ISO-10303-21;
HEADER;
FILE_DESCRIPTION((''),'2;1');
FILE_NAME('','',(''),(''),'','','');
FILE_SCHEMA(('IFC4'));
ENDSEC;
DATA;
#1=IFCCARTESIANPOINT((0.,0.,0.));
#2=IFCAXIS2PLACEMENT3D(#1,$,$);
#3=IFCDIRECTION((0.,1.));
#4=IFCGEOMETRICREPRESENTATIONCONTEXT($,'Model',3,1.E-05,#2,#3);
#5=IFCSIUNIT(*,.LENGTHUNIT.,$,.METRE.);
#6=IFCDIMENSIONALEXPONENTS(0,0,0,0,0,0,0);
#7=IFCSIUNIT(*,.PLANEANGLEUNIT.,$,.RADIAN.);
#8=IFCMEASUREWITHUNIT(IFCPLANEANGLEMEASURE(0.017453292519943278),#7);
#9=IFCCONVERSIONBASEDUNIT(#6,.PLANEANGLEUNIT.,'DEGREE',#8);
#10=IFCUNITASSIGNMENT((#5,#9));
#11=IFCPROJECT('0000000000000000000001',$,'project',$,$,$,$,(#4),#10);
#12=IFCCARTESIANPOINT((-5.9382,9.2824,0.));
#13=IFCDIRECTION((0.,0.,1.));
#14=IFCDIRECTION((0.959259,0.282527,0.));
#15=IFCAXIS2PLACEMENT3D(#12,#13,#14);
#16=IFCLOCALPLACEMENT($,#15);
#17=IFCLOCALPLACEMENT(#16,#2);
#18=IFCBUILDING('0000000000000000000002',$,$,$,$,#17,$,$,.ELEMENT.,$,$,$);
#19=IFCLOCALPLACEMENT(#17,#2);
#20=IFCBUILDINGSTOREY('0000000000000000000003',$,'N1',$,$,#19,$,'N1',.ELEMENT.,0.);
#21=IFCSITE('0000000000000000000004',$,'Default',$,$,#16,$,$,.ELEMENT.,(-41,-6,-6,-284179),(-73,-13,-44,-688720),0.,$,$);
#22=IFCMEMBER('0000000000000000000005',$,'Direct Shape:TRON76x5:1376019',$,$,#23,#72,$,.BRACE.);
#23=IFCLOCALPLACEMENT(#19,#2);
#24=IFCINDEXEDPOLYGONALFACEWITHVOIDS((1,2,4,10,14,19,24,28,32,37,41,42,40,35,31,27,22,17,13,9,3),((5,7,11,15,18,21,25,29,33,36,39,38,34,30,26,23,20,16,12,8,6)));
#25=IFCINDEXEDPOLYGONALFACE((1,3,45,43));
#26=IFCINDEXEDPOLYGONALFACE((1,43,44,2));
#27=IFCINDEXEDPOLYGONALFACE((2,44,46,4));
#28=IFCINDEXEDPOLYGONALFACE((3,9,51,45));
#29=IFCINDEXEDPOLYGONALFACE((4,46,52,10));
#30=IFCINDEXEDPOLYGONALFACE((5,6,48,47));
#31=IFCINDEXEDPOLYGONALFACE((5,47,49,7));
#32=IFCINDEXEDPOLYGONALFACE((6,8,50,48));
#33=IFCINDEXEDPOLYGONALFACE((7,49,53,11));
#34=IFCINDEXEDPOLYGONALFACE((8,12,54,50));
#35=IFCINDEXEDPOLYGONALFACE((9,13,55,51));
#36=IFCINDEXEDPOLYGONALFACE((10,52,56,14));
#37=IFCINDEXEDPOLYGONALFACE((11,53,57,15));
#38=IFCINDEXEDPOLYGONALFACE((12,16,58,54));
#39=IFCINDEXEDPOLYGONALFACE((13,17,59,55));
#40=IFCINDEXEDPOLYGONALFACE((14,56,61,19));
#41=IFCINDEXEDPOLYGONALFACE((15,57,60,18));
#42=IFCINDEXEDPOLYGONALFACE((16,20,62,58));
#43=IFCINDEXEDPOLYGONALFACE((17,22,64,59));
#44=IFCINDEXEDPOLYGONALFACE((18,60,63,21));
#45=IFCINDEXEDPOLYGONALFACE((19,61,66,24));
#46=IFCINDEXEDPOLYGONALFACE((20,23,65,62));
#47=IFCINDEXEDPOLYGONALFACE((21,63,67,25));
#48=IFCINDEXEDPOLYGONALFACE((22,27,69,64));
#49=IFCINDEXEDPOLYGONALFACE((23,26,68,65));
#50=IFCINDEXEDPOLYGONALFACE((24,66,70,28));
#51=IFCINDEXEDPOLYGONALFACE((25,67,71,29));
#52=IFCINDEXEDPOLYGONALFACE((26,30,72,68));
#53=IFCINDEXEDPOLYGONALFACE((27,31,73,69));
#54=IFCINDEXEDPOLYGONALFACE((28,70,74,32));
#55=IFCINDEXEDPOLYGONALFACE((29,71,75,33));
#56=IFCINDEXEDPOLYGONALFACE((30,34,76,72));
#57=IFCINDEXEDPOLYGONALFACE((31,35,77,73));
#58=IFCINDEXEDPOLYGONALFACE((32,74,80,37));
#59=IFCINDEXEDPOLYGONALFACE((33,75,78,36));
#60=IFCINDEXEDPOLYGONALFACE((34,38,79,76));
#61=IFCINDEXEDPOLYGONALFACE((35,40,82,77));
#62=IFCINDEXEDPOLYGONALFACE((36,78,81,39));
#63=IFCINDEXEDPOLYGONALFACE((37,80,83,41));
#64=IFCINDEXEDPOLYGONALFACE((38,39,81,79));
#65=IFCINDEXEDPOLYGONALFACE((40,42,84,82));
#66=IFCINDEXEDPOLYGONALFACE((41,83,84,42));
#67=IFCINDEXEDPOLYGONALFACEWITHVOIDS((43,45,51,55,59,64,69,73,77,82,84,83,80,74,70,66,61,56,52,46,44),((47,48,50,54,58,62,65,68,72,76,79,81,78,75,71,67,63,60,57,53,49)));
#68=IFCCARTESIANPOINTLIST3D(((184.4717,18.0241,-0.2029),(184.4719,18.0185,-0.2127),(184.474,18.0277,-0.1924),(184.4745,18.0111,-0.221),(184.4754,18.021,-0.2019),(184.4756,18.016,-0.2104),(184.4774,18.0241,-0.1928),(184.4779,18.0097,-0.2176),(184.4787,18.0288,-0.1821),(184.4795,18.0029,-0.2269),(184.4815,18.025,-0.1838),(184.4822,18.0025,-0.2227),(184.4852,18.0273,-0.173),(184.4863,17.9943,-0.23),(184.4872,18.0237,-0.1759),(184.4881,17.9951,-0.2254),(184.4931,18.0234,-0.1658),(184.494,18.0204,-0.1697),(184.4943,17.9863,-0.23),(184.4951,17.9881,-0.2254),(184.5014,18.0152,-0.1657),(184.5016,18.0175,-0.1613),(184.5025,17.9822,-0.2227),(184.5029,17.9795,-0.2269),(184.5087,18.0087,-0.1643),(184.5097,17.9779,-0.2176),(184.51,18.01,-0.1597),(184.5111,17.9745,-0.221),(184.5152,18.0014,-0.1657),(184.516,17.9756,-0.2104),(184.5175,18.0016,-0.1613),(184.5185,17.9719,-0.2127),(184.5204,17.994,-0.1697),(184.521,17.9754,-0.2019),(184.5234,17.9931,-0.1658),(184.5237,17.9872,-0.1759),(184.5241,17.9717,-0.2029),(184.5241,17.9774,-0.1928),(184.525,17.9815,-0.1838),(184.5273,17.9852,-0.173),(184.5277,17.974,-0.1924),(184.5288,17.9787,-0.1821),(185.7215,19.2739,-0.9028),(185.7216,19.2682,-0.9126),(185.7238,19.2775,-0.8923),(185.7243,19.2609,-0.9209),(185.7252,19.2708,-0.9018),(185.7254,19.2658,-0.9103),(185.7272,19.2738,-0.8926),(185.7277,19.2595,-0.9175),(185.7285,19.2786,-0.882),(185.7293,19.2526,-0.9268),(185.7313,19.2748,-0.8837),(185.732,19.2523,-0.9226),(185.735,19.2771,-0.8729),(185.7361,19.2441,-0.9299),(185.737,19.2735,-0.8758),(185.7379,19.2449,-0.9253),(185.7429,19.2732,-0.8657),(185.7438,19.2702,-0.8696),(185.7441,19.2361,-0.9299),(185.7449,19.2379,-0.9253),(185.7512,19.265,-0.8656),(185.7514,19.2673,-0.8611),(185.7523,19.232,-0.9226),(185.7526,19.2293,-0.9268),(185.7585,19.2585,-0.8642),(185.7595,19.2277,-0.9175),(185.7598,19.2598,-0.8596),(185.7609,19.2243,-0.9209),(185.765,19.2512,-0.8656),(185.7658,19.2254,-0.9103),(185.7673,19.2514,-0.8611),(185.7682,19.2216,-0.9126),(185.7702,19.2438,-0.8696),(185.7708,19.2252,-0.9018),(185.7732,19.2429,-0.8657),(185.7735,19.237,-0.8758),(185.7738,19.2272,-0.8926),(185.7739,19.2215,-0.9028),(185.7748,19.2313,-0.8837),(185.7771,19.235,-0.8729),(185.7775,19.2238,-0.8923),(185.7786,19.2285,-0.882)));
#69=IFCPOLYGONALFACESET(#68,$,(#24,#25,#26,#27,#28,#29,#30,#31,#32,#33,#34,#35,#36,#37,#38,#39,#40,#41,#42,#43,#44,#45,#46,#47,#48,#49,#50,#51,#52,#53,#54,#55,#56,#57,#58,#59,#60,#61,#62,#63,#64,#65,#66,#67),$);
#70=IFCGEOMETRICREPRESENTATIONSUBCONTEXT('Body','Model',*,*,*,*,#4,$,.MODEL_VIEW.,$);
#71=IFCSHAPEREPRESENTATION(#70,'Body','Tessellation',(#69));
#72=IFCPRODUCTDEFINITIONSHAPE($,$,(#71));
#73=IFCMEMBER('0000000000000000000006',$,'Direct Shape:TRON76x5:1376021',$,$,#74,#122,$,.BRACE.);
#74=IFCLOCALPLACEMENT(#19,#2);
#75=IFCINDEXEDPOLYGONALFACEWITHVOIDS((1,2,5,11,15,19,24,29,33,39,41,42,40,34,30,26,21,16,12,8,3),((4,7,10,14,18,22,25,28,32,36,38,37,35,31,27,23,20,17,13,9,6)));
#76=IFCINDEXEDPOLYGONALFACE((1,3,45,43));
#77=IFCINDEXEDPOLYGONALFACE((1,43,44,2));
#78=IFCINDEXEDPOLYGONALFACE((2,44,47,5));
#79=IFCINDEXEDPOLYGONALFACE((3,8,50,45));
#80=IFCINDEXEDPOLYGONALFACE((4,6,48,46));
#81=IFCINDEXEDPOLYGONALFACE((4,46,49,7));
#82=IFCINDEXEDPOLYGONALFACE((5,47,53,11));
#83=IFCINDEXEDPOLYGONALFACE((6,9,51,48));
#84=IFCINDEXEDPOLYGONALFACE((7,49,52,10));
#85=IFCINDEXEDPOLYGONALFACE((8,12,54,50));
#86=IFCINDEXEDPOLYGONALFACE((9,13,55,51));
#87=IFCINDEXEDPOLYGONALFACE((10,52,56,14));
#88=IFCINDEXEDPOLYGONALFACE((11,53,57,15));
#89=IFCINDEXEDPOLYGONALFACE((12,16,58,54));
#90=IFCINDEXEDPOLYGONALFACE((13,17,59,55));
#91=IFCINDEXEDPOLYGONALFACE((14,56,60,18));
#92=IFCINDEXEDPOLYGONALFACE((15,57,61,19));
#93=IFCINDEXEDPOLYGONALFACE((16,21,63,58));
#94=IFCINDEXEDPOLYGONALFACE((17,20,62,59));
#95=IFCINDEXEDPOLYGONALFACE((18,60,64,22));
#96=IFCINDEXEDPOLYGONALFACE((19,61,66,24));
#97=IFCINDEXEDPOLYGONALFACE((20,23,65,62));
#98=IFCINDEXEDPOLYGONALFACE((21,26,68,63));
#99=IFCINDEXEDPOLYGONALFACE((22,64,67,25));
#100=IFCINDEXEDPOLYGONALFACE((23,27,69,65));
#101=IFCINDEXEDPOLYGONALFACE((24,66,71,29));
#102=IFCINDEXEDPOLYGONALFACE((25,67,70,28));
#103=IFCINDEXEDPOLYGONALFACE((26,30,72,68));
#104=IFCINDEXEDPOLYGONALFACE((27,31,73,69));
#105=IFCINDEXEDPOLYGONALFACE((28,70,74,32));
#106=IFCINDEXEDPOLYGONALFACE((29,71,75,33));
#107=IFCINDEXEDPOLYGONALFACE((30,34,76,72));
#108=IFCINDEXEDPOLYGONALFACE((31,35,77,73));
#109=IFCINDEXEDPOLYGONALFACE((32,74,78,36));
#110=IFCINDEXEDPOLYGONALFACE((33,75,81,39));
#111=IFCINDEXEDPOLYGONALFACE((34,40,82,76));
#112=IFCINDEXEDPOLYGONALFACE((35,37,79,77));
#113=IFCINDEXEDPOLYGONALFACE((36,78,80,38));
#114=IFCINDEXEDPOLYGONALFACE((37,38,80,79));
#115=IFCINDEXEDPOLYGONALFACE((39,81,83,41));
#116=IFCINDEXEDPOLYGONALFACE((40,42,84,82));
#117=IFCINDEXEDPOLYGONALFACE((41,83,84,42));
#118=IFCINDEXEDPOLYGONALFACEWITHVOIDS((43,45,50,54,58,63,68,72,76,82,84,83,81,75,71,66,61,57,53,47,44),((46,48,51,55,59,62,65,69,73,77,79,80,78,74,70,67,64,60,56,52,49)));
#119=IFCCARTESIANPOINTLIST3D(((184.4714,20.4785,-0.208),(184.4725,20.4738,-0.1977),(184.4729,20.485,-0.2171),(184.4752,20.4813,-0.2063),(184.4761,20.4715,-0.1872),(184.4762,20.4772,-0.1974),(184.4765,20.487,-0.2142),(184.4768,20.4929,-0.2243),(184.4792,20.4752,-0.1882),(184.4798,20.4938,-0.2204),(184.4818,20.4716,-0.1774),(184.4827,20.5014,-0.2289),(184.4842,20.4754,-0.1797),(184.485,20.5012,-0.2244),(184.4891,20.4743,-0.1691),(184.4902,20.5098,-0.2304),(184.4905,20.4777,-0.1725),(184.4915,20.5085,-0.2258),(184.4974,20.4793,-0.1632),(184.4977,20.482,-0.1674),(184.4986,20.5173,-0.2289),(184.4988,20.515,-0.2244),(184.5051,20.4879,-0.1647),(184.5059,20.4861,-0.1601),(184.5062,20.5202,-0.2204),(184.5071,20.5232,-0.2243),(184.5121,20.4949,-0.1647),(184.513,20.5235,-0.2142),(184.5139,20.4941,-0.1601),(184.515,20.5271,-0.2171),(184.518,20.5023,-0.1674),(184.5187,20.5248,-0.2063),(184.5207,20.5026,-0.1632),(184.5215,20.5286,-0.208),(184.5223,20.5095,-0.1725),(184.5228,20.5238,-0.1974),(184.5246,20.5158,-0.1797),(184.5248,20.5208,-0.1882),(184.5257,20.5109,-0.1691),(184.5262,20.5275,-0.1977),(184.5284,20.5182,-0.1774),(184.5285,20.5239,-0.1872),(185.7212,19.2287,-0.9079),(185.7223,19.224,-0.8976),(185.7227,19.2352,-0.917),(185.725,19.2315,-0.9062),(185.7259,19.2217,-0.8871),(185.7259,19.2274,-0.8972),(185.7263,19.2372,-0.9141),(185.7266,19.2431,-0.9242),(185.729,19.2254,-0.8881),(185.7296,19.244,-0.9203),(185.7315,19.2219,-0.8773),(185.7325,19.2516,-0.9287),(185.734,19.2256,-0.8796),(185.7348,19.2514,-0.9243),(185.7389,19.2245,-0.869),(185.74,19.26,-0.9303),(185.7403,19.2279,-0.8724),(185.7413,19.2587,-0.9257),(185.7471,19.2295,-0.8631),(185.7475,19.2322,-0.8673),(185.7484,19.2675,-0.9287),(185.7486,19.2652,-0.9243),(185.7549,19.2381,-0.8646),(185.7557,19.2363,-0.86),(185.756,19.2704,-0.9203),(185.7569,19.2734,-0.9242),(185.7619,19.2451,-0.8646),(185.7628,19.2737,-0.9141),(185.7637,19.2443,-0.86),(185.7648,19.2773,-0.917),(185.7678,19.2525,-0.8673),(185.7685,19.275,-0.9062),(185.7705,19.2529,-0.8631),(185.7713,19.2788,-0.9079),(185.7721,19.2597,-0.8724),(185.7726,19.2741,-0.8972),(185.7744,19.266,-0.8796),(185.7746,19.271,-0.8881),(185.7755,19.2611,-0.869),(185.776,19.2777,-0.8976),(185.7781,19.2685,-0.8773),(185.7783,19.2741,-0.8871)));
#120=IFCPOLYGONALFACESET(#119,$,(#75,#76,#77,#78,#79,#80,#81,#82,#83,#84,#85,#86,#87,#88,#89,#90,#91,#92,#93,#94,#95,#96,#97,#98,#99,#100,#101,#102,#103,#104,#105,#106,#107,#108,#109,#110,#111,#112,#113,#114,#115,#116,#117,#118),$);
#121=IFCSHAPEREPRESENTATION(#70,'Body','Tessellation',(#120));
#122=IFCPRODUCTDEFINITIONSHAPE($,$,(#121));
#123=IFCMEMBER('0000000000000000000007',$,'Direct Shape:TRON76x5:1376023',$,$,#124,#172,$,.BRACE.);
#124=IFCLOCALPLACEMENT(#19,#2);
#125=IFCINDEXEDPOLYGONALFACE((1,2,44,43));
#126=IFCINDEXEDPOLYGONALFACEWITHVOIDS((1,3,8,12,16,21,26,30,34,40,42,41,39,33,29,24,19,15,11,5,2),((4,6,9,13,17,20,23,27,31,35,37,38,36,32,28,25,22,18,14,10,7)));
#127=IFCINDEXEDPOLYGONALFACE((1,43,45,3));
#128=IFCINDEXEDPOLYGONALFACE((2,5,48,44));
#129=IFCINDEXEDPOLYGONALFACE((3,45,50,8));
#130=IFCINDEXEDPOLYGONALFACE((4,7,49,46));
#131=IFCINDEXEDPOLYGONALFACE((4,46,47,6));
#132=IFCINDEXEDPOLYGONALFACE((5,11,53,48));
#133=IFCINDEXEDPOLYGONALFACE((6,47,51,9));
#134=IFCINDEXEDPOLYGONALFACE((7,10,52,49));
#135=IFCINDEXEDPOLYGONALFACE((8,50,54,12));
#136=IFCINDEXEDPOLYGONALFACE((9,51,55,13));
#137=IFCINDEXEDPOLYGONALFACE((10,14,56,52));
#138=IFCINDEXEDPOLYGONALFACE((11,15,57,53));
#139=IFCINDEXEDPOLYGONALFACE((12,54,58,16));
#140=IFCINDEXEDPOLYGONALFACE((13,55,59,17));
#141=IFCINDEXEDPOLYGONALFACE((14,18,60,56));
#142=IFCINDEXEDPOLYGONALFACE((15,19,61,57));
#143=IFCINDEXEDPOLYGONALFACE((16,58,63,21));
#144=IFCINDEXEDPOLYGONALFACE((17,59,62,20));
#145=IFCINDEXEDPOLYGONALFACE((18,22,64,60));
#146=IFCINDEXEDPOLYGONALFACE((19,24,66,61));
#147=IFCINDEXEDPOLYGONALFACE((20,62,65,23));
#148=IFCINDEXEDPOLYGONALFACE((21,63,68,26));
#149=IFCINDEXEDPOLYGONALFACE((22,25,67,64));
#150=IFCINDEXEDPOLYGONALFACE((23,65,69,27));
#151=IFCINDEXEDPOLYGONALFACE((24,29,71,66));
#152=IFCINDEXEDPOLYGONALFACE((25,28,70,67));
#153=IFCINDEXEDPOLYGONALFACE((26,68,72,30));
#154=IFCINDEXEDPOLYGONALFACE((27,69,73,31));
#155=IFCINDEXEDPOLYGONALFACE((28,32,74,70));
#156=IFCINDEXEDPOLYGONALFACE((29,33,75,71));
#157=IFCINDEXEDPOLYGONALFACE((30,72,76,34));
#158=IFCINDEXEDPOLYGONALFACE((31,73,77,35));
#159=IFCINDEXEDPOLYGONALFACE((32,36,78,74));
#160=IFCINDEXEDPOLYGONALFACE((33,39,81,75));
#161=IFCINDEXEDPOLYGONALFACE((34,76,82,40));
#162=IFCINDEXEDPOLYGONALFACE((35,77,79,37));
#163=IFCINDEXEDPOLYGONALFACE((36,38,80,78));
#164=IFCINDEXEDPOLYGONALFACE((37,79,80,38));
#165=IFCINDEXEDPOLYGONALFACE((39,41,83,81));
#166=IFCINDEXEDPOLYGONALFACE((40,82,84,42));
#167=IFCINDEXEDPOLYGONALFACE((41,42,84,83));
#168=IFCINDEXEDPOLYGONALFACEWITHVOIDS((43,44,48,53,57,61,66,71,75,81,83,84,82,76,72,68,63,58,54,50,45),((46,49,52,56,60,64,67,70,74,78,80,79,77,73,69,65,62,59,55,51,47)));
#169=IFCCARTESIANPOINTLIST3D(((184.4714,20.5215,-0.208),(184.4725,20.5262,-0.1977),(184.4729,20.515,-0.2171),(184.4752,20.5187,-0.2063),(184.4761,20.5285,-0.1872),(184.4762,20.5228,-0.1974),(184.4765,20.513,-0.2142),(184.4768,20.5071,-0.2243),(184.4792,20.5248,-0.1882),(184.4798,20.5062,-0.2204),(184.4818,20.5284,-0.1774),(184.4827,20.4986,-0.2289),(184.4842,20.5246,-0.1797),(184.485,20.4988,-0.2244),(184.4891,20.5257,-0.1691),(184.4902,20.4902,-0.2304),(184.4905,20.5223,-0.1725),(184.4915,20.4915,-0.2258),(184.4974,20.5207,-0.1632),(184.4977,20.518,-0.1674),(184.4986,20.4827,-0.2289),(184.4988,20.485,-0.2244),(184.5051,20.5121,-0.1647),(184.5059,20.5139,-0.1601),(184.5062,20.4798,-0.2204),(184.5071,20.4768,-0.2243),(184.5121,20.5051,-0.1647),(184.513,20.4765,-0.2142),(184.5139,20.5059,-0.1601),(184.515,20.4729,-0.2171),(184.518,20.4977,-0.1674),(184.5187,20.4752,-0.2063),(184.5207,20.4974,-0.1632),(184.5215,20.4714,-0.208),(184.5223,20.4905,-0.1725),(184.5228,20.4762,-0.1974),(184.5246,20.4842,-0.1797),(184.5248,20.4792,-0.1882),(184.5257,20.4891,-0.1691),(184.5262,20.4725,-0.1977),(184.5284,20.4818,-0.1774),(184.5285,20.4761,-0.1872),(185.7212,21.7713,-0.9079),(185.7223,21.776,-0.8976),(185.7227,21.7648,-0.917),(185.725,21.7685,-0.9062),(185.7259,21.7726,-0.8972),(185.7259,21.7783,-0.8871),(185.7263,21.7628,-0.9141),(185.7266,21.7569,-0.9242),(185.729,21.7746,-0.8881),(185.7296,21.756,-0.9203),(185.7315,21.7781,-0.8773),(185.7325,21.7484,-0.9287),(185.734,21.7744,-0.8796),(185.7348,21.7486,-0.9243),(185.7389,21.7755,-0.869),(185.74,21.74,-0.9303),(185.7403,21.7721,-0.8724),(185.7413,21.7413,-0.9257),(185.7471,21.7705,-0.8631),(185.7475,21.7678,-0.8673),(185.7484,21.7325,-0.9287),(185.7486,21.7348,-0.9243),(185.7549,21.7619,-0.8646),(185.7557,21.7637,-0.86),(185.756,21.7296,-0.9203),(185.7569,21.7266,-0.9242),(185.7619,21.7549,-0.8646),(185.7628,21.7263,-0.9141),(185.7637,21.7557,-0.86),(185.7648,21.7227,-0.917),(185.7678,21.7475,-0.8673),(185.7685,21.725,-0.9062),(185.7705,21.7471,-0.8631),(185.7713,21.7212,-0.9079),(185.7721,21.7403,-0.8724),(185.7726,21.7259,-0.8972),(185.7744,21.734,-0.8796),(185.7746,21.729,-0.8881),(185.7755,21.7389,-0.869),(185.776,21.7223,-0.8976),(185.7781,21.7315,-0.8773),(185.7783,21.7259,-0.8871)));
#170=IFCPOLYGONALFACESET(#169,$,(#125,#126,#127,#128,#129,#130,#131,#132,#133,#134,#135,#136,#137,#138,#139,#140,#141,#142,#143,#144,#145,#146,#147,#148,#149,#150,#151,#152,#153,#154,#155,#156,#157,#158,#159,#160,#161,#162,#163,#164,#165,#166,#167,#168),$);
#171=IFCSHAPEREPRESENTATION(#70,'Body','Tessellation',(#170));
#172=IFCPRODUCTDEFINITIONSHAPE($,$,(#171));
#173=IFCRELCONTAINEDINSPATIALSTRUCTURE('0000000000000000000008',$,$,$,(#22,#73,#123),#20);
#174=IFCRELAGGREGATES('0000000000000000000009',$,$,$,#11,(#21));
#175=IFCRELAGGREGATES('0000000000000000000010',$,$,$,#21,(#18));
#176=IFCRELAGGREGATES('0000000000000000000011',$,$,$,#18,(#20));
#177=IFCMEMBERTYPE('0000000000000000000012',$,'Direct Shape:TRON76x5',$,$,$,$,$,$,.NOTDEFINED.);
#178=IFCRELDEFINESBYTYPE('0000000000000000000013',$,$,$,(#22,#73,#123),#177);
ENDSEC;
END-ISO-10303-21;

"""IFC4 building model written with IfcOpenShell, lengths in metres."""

from ifc_helpers import new_model, entity, si_unit, converted_unit, direction, frame, frame_2d, origin, origin_2d_with_axis, place, context, subcontext, project, spatial, hollow_circle, extrude, type_object, element, save


model = new_model("IFC4")

# Units and contexts
model_context = context("Model", 3, precision=1e-05, world=origin(), true_north=direction((0.0, 1.0)))
body_context = subcontext(model_context, "Body", "Model", "MODEL_VIEW")
ifc_project = project(units=[si_unit("LENGTHUNIT", "METRE"), converted_unit("PLANEANGLEUNIT", "DEGREE", entity("IfcPlaneAngleMeasure", 0.017453292519943278), si_unit("PLANEANGLEUNIT", "RADIAN"), dimensions=[0, 0, 0, 0, 0, 0, 0])], contexts=[model_context])

# Site, building, storey
site_placement = place(None, frame((-5.9382, 9.2824, 0.0), z_axis=(0.0, 0.0, 1.0), x_axis=(0.959259, 0.282527, 0.0)))
site = spatial("IfcSite", under=ifc_project, at=site_placement, Name="Default", CompositionType="ELEMENT", RefLatitude=(-41, -6, -6, -284179), RefLongitude=(-73, -13, -44, -688720), RefElevation=0.0)
building_placement = place(site_placement, origin())
building = spatial("IfcBuilding", under=site, at=building_placement, CompositionType="ELEMENT")
storey_placement = place(building_placement, origin())
storey = spatial("IfcBuildingStorey", under=building, at=storey_placement, Name="N1", LongName="N1", CompositionType="ELEMENT", Elevation=0.0)

# Members
member_type_1 = type_object("IfcMemberType", Name="Direct Shape:TRON76x5", PredefinedType="NOTDEFINED")
member_1_placement = place(storey_placement, origin())
element("IfcMember", 1, at=member_1_placement, inside=storey, type_object=member_type_1, Name="Direct Shape:TRON76x5:1376019", PredefinedType="BRACE", context=body_context, shape_type="SweptSolid", body=[
    extrude(hollow_circle(Radius=0.0381, WallThickness=0.005, at=frame_2d((0.0, 0.0), x_axis=(1.0, 0.0))), frame((184.5001, 18.0001, -0.1951), z_axis=(0.65744, 0.65744, -0.368166), x_axis=(0.260333, 0.260333, 0.92976)), (0.0, 0.0, 1.0), 1.901),
])
member_2_placement = place(storey_placement, origin())
element("IfcMember", 2, at=member_2_placement, inside=storey, type_object=member_type_1, Name="Direct Shape:TRON76x5:1376021", PredefinedType="BRACE", context=body_context, shape_type="SweptSolid", body=[
    extrude(hollow_circle(Radius=0.0381, WallThickness=0.005, at=frame_2d((0.0, 0.0), x_axis=(1.0, 0.0))), frame((185.7499, 19.2501, -0.8949), z_axis=(-0.65744, 0.65744, 0.368166), x_axis=(-0.260333, 0.260333, -0.92976)), (0.0, 0.0, 1.0), 1.901),
])
member_3_placement = place(storey_placement, origin())
element("IfcMember", 3, at=member_3_placement, inside=storey, type_object=member_type_1, Name="Direct Shape:TRON76x5:1376023", PredefinedType="BRACE", context=body_context, shape_type="SweptSolid", body=[
    extrude(hollow_circle(Radius=0.0381, WallThickness=0.005, at=origin_2d_with_axis()), frame((185.7499, 21.7499, -0.8949), z_axis=(-0.65744, -0.65744, 0.368166), x_axis=(-0.260333, -0.260333, -0.92976)), (0.0, 0.0, 1.0), 1.901),
])

save(model, "model.ifc")
